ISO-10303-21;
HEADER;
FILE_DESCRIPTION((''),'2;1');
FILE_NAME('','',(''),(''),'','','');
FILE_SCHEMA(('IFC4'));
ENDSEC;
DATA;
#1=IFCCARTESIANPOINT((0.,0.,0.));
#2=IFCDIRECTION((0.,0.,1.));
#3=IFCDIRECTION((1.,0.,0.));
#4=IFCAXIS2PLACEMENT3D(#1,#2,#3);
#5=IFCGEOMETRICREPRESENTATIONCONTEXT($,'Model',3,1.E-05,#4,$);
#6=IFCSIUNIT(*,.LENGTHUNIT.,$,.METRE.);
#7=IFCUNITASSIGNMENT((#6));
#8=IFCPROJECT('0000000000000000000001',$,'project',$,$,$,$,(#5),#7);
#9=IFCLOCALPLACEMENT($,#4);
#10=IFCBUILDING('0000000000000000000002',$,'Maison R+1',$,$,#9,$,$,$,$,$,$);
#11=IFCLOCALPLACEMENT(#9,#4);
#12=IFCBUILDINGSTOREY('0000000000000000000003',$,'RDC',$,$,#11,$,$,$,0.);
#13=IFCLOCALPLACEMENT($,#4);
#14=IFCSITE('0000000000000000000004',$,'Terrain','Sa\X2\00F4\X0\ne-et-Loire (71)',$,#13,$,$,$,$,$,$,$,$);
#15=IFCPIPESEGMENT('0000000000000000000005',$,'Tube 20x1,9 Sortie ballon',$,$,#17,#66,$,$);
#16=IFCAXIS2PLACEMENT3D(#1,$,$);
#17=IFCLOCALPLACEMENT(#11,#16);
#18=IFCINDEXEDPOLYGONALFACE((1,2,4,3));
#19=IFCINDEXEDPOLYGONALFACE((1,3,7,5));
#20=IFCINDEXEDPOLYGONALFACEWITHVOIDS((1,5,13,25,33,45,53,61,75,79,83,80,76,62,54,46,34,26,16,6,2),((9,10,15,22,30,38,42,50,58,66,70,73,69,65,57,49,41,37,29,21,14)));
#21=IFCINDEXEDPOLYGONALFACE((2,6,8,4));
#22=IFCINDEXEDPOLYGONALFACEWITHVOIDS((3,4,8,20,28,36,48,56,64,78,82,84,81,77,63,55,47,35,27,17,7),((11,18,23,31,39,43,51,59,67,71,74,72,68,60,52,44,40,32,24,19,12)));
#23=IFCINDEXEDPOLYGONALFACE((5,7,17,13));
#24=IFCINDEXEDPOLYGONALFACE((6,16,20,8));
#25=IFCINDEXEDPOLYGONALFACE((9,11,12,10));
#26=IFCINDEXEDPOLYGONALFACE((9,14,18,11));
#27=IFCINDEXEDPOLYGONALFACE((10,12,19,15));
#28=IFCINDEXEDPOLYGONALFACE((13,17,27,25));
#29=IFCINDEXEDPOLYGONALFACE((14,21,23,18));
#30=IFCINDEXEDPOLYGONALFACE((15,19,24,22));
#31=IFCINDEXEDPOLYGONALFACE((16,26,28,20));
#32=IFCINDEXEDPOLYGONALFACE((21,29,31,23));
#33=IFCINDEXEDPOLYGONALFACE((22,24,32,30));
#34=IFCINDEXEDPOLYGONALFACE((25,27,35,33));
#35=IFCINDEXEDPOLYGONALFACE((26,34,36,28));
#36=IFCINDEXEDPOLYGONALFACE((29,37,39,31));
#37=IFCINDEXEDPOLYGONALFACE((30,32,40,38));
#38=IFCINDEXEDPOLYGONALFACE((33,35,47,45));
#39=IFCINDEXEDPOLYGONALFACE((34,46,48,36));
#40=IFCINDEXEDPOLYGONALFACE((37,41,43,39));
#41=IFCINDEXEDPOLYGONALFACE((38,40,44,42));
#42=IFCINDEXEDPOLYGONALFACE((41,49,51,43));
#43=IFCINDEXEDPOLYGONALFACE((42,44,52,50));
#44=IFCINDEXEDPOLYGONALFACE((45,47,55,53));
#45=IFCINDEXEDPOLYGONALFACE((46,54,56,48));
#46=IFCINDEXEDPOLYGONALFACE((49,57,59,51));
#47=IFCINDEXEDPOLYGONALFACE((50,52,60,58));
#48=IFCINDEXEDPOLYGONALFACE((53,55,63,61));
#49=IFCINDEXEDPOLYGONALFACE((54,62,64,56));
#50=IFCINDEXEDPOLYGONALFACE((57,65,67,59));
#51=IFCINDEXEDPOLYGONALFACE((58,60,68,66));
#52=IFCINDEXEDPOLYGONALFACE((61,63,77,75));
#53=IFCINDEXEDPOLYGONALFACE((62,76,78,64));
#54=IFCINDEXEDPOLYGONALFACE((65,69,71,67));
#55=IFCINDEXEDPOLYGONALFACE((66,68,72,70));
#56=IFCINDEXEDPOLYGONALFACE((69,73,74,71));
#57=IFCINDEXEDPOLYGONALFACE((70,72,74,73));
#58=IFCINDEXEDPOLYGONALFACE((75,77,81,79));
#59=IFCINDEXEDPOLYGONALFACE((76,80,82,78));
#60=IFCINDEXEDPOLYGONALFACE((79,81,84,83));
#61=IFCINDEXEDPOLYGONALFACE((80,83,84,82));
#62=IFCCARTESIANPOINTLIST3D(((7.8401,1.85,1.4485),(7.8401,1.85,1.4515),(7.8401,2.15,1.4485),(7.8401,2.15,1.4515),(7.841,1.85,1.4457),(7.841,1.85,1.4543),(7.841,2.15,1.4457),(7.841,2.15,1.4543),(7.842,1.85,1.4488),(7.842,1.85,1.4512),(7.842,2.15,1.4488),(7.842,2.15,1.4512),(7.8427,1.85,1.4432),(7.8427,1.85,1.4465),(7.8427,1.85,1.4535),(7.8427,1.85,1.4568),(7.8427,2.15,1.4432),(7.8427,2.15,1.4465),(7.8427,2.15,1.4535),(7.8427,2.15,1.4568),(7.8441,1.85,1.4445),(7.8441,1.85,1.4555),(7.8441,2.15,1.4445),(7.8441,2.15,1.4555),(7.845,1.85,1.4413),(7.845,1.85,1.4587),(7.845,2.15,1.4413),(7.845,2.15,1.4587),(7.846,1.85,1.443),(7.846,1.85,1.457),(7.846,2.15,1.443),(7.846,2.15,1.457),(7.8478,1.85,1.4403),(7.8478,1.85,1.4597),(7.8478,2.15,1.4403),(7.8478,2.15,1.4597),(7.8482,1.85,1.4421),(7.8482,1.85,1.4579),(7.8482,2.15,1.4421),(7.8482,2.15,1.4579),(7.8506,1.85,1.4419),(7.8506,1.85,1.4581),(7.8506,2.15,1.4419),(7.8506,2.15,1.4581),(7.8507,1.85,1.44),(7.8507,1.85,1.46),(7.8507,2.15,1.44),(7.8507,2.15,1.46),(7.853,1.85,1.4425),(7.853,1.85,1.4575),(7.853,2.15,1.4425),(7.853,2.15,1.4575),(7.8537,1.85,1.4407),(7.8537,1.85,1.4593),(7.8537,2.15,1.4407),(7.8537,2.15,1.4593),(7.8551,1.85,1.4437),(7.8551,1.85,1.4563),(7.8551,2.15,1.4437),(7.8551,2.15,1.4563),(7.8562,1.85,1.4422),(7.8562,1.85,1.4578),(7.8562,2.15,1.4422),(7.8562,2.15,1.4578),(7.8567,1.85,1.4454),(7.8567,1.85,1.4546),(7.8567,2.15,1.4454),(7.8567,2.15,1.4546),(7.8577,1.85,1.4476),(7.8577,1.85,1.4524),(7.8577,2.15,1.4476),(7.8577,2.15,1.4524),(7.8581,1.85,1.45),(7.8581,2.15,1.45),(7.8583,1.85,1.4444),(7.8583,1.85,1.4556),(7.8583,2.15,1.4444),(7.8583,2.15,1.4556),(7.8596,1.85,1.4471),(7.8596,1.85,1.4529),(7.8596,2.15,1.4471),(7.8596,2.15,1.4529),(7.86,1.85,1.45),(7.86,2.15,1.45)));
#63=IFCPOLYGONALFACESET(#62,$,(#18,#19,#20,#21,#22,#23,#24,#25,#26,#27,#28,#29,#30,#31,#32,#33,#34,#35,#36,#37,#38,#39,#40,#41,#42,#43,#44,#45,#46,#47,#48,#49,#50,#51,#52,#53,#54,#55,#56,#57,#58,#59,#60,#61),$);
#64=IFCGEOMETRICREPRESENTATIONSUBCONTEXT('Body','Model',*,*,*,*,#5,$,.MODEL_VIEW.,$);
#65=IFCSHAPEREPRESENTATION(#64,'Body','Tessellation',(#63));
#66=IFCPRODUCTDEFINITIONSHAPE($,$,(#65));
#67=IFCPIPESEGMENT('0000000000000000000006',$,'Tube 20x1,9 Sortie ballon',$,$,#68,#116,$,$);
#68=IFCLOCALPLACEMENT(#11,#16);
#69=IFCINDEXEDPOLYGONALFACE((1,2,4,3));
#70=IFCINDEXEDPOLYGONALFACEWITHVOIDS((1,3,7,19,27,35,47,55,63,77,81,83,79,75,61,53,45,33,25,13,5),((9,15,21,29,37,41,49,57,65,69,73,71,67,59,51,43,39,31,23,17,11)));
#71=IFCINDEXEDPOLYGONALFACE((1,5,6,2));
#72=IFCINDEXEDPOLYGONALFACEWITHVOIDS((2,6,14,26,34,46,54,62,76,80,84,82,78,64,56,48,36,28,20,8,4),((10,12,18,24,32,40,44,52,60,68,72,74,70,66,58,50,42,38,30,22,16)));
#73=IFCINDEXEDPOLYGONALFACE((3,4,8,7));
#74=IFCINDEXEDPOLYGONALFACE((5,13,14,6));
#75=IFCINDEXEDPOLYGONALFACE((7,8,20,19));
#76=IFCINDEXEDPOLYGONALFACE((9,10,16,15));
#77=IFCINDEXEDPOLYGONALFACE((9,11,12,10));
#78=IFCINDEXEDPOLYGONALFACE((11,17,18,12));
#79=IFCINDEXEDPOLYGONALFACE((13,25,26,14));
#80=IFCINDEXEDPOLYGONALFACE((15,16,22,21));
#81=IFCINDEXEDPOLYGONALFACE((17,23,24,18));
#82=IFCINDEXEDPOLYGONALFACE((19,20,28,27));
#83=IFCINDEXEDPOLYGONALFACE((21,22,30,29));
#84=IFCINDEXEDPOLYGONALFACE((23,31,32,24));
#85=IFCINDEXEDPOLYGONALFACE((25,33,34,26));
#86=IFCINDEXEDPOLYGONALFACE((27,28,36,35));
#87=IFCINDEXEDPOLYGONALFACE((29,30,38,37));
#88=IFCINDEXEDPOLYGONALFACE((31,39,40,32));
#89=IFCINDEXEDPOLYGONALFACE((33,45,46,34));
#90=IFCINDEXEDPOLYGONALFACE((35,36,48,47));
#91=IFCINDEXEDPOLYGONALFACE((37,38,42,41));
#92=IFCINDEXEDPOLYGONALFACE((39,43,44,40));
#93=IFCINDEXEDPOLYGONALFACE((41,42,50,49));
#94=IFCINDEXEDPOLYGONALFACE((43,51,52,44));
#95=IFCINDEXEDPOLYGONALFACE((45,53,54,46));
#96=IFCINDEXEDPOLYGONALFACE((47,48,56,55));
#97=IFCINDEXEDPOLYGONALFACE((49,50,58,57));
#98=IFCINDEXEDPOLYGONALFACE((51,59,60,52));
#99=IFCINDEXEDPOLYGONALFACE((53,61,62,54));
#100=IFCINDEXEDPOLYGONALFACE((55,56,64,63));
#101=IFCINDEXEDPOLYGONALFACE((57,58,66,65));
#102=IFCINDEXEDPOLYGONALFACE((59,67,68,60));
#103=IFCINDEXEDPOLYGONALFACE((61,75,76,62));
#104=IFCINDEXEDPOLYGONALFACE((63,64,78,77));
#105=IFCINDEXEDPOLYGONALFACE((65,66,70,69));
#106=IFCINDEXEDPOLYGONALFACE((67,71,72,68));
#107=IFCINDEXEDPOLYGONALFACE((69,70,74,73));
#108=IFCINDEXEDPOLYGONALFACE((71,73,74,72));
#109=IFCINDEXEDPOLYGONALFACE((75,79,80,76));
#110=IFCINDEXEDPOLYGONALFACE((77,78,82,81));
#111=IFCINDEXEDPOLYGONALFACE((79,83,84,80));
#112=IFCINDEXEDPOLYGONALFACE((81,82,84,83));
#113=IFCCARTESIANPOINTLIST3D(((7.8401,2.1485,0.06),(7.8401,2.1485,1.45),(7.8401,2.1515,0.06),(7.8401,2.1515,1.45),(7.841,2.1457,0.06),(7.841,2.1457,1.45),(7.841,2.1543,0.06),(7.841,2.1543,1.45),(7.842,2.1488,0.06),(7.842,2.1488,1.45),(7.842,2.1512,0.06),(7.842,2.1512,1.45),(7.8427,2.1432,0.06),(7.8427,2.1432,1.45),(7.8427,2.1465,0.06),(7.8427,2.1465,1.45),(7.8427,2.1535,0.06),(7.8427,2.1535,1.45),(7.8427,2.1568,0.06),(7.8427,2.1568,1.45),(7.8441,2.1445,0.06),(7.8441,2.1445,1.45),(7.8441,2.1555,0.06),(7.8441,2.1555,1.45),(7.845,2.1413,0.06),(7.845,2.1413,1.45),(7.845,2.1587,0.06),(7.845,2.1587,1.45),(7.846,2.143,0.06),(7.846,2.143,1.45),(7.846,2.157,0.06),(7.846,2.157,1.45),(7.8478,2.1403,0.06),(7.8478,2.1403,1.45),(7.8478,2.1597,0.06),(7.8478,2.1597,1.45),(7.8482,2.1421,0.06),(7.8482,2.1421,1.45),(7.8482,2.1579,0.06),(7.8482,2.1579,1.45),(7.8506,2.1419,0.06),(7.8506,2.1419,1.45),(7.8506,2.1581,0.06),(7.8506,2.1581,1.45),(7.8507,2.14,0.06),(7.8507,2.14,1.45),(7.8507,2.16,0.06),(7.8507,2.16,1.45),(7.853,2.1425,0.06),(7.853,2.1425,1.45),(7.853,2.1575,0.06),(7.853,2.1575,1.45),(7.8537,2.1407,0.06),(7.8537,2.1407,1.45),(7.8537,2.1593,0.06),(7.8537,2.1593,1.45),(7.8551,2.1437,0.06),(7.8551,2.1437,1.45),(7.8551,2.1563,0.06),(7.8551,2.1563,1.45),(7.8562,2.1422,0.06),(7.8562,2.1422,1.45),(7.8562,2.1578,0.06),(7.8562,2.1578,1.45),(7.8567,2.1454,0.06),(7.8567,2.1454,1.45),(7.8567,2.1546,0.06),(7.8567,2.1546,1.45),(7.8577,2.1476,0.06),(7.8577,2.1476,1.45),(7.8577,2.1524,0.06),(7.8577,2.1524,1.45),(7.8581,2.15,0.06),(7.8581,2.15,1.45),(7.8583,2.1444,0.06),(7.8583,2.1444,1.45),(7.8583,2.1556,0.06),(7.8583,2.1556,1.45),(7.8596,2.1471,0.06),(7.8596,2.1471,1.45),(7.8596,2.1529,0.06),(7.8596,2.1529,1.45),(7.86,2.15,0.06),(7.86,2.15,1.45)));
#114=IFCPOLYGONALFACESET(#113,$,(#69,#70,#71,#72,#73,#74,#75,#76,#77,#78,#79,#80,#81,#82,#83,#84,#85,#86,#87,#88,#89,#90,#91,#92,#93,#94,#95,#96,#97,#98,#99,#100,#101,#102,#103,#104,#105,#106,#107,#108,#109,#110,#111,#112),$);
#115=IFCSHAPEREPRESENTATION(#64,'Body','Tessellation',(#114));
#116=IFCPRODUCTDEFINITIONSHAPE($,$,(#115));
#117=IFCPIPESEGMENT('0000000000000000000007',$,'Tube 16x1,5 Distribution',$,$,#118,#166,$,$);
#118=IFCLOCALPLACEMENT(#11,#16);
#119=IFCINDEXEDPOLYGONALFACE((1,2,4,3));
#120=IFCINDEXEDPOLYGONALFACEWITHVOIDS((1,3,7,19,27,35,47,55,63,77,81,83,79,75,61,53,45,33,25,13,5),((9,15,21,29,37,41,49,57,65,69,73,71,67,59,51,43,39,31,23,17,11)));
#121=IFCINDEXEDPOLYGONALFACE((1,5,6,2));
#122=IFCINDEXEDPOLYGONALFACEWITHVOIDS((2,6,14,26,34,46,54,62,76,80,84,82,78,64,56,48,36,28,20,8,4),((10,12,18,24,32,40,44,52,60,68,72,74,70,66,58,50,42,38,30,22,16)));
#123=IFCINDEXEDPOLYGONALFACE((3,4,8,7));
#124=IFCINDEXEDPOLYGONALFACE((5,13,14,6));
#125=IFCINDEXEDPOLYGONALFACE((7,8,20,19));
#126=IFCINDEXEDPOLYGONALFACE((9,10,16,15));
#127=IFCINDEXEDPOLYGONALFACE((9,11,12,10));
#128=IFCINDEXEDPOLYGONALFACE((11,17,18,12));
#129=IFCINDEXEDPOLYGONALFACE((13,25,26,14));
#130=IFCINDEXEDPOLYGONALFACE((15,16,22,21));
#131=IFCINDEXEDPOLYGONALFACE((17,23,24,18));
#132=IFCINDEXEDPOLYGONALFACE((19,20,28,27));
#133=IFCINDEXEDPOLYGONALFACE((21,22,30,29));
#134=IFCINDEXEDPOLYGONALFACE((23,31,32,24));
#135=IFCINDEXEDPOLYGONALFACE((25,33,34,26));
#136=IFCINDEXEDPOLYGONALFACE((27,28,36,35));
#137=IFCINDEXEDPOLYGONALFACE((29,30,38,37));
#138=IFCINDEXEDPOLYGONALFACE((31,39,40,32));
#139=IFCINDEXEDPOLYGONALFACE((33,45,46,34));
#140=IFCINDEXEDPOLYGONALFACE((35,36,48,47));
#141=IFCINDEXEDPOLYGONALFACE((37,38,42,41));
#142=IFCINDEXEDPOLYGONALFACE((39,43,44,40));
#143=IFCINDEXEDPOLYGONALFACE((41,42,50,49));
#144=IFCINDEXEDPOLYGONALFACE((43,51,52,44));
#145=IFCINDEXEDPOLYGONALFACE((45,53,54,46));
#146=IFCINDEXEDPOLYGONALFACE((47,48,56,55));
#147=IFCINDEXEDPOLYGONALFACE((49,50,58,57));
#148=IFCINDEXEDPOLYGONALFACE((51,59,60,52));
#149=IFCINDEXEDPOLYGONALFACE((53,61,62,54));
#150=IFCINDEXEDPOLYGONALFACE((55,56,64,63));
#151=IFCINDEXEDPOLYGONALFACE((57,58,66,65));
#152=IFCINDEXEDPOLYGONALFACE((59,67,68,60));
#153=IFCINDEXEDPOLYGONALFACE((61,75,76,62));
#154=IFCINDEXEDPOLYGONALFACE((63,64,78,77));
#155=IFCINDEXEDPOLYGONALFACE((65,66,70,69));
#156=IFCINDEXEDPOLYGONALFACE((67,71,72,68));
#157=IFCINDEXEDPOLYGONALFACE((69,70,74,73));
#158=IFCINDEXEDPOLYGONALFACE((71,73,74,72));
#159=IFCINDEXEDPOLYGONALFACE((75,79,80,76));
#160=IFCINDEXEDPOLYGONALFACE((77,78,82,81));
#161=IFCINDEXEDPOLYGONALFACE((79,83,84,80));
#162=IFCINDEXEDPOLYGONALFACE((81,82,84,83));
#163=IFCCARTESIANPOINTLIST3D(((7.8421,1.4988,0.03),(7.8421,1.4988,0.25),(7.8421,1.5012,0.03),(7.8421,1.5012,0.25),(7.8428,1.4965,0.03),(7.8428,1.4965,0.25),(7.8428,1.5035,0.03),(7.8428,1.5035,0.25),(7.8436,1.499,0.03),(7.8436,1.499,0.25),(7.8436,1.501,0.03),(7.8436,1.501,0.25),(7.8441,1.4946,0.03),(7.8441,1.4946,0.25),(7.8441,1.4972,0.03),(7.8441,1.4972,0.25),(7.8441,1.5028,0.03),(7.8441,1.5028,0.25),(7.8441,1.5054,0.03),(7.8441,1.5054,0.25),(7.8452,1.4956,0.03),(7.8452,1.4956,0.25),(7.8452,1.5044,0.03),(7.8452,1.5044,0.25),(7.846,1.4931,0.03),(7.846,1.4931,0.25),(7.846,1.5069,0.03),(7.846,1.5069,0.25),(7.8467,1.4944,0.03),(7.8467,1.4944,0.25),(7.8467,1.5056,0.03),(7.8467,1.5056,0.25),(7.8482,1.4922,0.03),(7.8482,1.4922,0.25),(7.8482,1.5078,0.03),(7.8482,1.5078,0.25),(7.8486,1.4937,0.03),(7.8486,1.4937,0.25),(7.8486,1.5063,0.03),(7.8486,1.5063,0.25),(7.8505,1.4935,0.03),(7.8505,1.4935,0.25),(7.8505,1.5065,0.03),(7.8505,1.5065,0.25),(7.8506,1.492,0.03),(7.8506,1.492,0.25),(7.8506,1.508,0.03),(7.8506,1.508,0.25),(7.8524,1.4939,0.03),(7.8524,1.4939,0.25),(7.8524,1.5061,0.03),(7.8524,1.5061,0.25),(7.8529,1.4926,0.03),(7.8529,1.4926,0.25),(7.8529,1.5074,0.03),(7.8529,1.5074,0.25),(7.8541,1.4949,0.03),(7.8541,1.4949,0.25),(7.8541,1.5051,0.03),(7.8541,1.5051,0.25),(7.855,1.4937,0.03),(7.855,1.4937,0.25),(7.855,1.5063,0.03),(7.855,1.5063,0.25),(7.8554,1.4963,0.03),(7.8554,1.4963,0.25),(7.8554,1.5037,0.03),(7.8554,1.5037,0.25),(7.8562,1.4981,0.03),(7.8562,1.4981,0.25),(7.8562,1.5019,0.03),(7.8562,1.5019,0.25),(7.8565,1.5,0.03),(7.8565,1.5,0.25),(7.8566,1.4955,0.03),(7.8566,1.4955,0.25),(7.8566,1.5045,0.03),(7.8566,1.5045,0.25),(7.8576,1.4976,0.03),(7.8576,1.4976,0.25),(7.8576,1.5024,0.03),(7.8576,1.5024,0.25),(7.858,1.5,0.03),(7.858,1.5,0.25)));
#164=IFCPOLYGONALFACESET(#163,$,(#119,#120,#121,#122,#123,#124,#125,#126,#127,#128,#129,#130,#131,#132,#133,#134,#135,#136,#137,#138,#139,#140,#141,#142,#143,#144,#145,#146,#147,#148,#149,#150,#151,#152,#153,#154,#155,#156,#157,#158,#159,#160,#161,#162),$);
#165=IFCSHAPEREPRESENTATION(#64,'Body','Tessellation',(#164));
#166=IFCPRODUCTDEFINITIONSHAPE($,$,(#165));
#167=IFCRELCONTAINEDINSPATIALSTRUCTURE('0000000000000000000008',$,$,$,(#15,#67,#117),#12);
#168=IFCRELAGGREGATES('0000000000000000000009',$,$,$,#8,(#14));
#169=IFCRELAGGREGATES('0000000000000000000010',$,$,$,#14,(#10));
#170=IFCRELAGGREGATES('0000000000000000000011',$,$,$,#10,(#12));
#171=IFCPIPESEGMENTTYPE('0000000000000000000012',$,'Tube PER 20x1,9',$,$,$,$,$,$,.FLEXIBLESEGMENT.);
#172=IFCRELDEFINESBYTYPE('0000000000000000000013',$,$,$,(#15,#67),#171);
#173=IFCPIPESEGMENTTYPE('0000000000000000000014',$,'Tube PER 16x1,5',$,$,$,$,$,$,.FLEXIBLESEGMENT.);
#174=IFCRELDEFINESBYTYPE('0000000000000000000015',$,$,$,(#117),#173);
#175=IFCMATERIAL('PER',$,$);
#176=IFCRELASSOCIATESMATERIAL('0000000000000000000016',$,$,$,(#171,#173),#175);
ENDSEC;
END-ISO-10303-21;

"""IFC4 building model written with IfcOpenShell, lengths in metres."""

from ifc_helpers import new_model, si_unit, frame, origin_with_axes, place, context, subcontext, project, spatial, hollow_circle, extrude, material, type_object, element, save


model = new_model("IFC4")

# Units and contexts
model_context = context("Model", 3, precision=1e-05, world=origin_with_axes())
body_context = subcontext(model_context, "Body", "Model", "MODEL_VIEW")
ifc_project = project(units=[si_unit("LENGTHUNIT", "METRE")], contexts=[model_context])

# Site, building, storey
site_placement = place(None, origin_with_axes())
site = spatial("IfcSite", under=ifc_project, at=site_placement, Name="Terrain", Description="Saône-et-Loire (71)")
building_placement = place(None, origin_with_axes())
building = spatial("IfcBuilding", under=site, at=building_placement, Name="Maison R+1")
storey_placement = place(building_placement, origin_with_axes())
storey = spatial("IfcBuildingStorey", under=building, at=storey_placement, Name="RDC", Elevation=0.0)

# Pipe segments
ifc_material_1 = material(Name="PER")
pipe_segment_type_1 = type_object("IfcPipeSegmentType", Name="Tube PER 20x1,9", PredefinedType="FLEXIBLESEGMENT", material=ifc_material_1)
pipe_segment_1_placement = place(storey_placement, frame((7.85, 1.85, 1.45), z_axis=(0.0, 1.0, 0.0), x_axis=(1.0, 0.0, 0.0)))
element("IfcPipeSegment", 1, at=pipe_segment_1_placement, inside=storey, type_object=pipe_segment_type_1, Name="Tube 20x1,9 Sortie ballon", context=body_context, shape_type="SweptSolid", body=[
    extrude(hollow_circle(Radius=0.01, WallThickness=0.0019), origin_with_axes(), (0.0, 0.0, 1.0), 0.3),
])
pipe_segment_2_placement = place(storey_placement, frame((7.85, 2.15, 1.45), z_axis=(0.0, 0.0, -1.0), x_axis=(1.0, 0.0, 0.0)))
element("IfcPipeSegment", 2, at=pipe_segment_2_placement, inside=storey, type_object=pipe_segment_type_1, Name="Tube 20x1,9 Sortie ballon", context=body_context, shape_type="SweptSolid", body=[
    extrude(hollow_circle(Radius=0.01, WallThickness=0.0019), origin_with_axes(), (0.0, 0.0, 1.0), 1.39),
])
pipe_segment_type_2 = type_object("IfcPipeSegmentType", Name="Tube PER 16x1,5", PredefinedType="FLEXIBLESEGMENT", material=ifc_material_1)
pipe_segment_3_placement = place(storey_placement, frame((7.85, 1.5, 0.03), z_axis=(0.0, 0.0, 1.0), x_axis=(1.0, 0.0, 0.0)))
element("IfcPipeSegment", 3, at=pipe_segment_3_placement, inside=storey, type_object=pipe_segment_type_2, Name="Tube 16x1,5 Distribution", context=body_context, shape_type="SweptSolid", body=[
    extrude(hollow_circle(Radius=0.008, WallThickness=0.0015), origin_with_axes(), (0.0, 0.0, 1.0), 0.22),
])

save(model, "model.ifc")
